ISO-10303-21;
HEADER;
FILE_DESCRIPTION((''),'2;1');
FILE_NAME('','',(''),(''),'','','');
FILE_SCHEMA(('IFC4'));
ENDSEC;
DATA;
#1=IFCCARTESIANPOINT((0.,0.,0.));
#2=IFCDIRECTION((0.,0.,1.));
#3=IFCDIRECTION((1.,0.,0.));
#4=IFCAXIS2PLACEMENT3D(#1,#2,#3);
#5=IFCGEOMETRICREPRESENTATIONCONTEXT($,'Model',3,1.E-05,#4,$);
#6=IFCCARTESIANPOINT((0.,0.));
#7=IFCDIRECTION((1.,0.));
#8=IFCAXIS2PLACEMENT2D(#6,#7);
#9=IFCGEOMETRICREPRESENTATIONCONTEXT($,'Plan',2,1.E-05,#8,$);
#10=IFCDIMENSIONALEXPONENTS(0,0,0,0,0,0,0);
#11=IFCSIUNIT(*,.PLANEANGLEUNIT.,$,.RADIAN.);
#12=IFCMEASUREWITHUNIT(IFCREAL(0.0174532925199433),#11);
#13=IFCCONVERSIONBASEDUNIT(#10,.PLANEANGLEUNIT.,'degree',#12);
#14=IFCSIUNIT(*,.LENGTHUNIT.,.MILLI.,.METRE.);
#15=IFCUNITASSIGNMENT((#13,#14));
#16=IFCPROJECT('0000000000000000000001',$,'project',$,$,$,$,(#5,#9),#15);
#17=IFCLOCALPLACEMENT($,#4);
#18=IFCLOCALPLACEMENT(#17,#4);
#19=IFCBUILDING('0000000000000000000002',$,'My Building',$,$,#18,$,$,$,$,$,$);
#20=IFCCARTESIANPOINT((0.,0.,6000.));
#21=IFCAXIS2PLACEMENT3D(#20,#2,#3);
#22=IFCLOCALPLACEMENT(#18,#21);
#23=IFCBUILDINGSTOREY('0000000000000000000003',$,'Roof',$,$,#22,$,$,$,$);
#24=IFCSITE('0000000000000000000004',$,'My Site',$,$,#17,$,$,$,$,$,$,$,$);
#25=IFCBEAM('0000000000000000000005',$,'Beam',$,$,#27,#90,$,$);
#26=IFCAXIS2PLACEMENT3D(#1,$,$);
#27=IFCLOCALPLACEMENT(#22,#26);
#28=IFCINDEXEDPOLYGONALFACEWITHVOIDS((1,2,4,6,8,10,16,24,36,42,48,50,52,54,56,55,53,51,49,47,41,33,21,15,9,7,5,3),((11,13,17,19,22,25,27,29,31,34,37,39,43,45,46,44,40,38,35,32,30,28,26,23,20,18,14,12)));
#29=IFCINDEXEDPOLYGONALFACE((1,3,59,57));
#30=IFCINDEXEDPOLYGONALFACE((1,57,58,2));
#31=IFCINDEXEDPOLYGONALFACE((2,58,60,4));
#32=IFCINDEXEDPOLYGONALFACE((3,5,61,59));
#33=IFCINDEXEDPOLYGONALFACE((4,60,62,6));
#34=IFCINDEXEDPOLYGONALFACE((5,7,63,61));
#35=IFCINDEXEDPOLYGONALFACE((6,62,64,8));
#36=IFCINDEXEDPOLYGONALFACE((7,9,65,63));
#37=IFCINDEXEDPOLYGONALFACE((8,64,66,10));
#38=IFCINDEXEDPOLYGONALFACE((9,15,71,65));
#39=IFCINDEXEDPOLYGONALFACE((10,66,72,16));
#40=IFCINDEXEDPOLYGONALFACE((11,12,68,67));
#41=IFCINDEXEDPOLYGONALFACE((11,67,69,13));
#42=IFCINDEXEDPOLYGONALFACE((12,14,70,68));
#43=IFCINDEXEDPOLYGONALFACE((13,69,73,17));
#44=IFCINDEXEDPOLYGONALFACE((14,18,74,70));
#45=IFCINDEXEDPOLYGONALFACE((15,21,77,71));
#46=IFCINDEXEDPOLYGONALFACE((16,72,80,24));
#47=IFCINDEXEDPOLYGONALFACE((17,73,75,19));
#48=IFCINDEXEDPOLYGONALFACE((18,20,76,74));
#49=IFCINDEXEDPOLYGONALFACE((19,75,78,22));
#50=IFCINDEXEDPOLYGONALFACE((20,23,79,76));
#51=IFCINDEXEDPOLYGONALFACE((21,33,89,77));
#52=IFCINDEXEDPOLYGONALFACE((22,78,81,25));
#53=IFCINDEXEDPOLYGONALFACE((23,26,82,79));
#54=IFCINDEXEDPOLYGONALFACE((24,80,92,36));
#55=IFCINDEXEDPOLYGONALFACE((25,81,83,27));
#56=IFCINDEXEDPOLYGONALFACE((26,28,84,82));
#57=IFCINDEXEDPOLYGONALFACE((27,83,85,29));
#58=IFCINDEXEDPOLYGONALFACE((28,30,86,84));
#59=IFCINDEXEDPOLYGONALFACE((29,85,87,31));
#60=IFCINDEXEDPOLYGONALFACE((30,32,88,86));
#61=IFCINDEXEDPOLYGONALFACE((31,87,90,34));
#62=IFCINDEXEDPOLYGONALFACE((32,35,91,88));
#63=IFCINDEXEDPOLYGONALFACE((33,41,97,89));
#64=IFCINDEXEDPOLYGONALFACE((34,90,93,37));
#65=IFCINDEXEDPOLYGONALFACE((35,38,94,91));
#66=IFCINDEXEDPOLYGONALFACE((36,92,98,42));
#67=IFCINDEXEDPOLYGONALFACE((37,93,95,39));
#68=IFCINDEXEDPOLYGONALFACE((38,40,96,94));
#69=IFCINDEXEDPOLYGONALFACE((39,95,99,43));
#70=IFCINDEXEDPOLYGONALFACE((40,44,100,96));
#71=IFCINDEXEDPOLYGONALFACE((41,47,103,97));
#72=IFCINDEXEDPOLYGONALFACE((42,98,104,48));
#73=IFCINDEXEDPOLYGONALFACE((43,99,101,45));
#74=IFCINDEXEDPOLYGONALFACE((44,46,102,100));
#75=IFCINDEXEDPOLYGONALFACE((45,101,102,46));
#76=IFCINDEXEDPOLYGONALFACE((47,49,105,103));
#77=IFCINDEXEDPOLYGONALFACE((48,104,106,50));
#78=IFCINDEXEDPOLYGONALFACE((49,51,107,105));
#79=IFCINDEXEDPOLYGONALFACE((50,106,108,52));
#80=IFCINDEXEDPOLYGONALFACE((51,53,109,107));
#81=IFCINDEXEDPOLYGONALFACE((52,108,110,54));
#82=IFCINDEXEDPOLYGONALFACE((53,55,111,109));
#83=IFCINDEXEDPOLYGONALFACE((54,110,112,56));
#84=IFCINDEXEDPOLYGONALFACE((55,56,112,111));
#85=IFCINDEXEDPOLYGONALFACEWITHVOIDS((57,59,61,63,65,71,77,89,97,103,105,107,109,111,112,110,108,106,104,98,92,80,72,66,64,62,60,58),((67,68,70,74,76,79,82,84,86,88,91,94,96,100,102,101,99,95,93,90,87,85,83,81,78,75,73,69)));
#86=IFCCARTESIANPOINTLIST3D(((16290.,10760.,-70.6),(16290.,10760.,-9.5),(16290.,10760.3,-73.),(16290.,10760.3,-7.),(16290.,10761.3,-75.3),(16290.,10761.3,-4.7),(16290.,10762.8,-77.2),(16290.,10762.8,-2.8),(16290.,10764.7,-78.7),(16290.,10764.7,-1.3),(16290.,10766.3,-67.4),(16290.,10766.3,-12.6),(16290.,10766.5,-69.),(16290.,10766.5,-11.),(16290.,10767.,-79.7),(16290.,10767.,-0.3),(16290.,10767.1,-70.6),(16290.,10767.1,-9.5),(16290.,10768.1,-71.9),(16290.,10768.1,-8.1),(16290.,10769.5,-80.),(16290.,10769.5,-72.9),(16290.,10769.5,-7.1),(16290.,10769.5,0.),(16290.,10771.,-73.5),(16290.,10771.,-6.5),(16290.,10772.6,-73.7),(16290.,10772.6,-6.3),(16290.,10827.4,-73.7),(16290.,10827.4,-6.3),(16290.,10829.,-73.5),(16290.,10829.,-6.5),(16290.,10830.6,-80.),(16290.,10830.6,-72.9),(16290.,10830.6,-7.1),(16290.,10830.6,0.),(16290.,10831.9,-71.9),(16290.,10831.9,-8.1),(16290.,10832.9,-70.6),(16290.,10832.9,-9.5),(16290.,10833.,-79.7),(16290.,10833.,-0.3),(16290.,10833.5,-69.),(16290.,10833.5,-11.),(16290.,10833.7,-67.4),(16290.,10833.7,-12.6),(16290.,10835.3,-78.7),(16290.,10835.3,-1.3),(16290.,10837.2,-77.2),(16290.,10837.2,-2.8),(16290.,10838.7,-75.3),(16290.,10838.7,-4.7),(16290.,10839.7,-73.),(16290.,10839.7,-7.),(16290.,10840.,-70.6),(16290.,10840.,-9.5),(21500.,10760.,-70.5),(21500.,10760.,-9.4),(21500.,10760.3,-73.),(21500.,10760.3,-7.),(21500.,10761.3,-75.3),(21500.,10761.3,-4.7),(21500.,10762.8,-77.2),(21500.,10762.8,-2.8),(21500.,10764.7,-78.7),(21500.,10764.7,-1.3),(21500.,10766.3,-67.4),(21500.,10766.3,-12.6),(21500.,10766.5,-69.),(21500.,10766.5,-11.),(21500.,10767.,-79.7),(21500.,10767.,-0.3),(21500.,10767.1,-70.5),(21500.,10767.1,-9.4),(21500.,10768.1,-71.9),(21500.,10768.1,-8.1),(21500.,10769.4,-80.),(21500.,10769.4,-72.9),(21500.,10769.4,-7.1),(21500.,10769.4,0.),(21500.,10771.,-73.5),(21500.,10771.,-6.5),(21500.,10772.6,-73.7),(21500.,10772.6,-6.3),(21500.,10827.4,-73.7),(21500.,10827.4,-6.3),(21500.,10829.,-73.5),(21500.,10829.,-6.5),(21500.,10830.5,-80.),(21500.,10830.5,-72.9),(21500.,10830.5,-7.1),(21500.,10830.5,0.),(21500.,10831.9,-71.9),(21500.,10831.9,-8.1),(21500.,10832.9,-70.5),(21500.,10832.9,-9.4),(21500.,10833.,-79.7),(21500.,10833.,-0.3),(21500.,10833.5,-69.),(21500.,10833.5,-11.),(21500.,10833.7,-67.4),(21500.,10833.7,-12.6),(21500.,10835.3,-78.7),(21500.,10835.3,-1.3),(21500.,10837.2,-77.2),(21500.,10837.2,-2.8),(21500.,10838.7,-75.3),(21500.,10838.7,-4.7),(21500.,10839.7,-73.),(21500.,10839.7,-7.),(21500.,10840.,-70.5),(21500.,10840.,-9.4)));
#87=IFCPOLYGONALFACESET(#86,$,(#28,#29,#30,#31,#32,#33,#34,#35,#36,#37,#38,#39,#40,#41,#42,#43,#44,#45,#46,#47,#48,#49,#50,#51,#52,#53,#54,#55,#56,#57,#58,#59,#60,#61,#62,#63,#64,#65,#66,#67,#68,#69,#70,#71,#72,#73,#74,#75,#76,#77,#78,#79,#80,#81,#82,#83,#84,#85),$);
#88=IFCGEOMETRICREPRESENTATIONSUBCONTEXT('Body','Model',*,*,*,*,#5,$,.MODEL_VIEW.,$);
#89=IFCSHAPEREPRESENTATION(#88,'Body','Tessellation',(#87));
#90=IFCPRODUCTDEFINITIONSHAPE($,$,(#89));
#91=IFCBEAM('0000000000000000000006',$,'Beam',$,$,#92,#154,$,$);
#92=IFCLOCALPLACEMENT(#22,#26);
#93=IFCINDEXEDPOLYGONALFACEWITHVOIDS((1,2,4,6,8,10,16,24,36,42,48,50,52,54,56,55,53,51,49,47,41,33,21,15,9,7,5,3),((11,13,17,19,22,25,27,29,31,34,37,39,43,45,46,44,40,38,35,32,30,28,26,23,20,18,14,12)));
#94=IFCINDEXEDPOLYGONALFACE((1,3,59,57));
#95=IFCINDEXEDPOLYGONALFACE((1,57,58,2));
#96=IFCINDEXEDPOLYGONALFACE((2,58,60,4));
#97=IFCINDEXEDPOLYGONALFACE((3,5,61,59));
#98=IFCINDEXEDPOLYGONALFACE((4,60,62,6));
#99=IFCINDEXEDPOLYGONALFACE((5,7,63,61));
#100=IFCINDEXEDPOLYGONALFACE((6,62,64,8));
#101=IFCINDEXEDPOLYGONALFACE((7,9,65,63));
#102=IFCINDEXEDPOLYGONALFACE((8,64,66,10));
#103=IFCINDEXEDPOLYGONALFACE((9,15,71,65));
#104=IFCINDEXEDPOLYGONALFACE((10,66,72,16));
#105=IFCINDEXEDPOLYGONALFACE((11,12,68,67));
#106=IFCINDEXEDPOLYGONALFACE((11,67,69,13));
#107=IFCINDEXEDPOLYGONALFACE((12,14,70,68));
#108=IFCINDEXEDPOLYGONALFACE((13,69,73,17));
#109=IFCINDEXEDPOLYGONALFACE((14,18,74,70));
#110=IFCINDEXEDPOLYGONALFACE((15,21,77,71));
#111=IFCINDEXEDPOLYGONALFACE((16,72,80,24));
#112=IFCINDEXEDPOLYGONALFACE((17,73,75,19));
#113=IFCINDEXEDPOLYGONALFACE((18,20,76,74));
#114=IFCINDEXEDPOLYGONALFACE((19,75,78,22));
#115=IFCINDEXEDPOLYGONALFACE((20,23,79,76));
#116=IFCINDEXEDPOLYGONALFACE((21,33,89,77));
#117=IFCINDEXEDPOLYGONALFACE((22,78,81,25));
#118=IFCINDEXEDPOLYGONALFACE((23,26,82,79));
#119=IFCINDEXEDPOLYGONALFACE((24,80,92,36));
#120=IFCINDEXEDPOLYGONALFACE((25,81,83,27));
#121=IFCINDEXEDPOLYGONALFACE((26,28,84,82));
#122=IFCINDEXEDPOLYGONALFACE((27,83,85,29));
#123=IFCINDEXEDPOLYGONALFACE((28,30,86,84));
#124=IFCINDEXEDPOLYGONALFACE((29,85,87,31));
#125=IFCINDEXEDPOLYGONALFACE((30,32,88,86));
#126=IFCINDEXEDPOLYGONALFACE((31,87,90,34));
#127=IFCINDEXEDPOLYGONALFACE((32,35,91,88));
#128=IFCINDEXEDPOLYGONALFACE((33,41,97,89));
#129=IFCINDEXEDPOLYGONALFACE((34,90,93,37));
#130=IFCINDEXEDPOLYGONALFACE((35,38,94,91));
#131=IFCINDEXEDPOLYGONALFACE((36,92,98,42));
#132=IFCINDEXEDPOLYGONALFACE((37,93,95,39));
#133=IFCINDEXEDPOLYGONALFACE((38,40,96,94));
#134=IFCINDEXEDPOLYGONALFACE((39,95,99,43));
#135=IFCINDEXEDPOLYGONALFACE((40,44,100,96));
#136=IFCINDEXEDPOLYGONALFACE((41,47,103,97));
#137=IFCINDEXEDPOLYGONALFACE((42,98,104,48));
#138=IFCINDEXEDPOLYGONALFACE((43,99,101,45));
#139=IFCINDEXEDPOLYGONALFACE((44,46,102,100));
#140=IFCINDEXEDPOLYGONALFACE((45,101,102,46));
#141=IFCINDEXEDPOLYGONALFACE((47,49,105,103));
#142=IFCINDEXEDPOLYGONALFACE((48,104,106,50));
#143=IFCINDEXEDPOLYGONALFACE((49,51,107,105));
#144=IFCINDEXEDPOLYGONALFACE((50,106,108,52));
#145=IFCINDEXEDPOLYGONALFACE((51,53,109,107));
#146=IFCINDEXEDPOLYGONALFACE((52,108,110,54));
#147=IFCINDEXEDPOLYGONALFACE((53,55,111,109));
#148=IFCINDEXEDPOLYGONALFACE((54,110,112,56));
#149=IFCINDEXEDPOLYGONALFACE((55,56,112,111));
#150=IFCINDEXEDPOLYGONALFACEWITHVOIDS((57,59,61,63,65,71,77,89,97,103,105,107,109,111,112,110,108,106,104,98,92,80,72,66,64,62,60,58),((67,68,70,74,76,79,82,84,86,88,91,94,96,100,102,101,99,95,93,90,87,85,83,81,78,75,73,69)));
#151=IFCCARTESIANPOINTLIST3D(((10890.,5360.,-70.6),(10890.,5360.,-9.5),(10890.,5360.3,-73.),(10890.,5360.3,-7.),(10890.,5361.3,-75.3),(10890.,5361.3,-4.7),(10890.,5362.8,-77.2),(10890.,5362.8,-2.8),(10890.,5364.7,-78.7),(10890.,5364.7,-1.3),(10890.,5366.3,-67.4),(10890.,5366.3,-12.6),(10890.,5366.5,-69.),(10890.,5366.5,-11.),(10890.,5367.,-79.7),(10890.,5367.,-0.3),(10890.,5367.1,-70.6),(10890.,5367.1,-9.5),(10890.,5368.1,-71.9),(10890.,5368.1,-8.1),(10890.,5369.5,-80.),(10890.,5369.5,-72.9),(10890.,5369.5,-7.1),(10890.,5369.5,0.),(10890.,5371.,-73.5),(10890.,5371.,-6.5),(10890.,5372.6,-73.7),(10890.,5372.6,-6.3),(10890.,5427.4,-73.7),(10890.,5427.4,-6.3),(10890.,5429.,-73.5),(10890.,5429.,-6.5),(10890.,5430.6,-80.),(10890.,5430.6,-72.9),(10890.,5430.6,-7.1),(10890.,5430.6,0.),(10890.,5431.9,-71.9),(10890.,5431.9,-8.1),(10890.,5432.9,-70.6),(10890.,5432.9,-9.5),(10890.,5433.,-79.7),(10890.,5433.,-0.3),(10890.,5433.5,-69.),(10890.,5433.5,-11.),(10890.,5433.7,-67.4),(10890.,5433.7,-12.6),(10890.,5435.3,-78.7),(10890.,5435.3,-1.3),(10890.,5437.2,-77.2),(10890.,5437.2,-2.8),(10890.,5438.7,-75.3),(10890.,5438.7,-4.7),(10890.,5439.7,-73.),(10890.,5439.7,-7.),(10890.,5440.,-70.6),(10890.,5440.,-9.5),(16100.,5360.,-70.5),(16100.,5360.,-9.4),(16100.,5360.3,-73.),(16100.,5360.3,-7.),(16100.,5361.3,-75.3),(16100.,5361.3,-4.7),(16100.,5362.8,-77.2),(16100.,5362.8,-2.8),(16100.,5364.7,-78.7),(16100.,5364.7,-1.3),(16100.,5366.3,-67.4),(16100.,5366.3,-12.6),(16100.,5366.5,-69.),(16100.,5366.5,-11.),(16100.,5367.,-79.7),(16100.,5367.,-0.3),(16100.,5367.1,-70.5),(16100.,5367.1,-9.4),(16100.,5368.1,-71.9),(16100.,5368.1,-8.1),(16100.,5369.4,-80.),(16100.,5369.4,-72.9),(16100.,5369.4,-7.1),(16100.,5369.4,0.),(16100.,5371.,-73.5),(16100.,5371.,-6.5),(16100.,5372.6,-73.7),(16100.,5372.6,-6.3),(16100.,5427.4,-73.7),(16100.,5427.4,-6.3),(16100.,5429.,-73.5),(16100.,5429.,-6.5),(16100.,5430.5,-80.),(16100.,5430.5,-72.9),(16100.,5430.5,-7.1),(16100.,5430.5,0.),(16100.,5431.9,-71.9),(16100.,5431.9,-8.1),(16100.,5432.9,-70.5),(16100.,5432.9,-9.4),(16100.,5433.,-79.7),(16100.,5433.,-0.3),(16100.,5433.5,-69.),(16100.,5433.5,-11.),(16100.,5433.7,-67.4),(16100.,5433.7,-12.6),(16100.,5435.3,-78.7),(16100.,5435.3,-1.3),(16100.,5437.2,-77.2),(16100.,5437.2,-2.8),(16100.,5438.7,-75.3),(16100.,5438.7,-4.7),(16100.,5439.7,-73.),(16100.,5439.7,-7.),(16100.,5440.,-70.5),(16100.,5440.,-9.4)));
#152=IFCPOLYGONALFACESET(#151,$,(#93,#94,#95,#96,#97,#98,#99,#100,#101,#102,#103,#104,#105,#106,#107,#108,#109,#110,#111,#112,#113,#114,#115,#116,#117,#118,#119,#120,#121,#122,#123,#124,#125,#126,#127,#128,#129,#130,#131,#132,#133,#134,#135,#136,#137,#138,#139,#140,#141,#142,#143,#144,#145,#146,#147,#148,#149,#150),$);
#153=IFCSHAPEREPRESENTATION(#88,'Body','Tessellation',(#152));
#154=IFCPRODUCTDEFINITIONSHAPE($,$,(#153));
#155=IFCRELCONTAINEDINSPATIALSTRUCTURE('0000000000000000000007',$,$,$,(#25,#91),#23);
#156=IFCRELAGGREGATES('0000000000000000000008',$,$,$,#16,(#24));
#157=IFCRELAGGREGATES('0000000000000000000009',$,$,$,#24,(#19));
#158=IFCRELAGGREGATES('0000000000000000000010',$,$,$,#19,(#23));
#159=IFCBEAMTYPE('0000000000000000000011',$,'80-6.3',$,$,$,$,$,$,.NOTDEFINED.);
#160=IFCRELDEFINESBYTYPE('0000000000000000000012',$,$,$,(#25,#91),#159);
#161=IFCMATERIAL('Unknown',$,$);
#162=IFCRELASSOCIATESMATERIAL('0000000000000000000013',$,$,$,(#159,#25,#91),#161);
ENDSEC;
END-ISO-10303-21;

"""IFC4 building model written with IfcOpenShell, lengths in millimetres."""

from ifc_helpers import new_model, entity, si_unit, converted_unit, frame, origin_with_axes, origin_2d_with_axis, place, context, subcontext, project, spatial, hollow_rectangle, extrude, material, material_profile, profile_set, profile_usage, type_object, element, save


model = new_model("IFC4")

# Units and contexts
model_context = context("Model", 3, precision=1e-05, world=origin_with_axes())
plan_context = context("Plan", 2, precision=1e-05, world=origin_2d_with_axis())
body_context = subcontext(model_context, "Body", "Model", "MODEL_VIEW")
ifc_project = project(units=[converted_unit("PLANEANGLEUNIT", "degree", entity("IfcReal", 0.0174532925199433), si_unit("PLANEANGLEUNIT", "RADIAN"), dimensions=[0, 0, 0, 0, 0, 0, 0]), si_unit("LENGTHUNIT", "METRE", prefix="MILLI")], contexts=[model_context, plan_context])

# Site, building, storey
site_placement = place(None, origin_with_axes())
site = spatial("IfcSite", under=ifc_project, at=site_placement, Name="My Site")
building_placement = place(site_placement, origin_with_axes())
building = spatial("IfcBuilding", under=site, at=building_placement, Name="My Building")
storey_placement = place(building_placement, frame((0.0, 0.0, 6000.0), z_axis=(0.0, 0.0, 1.0), x_axis=(1.0, 0.0, 0.0)))
storey = spatial("IfcBuildingStorey", under=building, at=storey_placement, Name="Roof")

# Beams
ifc_material = material(Name="Unknown")
ifc_material_profile_1 = material_profile(ifc_material, hollow_rectangle(XDim=80.0, YDim=80.0, WallThickness=6.3, InnerFilletRadius=6.3, OuterFilletRadius=9.4))
ifc_profile_set_1 = profile_set([ifc_material_profile_1])
ifc_profile_usage_1 = profile_usage(ifc_profile_set_1, cardinal=8)
beam_type_1 = type_object("IfcBeamType", Name="80-6.3", PredefinedType="NOTDEFINED", material=ifc_profile_set_1)
beam_1_placement = place(storey_placement, frame((16290.0, 10800.0, 0.0), z_axis=(1.0, 0.0, 0.0), x_axis=(0.0, 1.0, 0.0)))
element("IfcBeam", 1, at=beam_1_placement, inside=storey, type_object=beam_type_1, material=ifc_profile_usage_1, Name="Beam", context=body_context, shape_type="SweptSolid", body=[
    extrude(hollow_rectangle(XDim=80.0, YDim=80.0, WallThickness=6.3, InnerFilletRadius=6.3, OuterFilletRadius=9.4), frame((0.0, -40.0, 0.0), z_axis=(0.0, 0.0, 1.0), x_axis=(1.0, 0.0, 0.0)), (0.0, 0.0, 1.0), 5210.0),
])
ifc_profile_usage_2 = profile_usage(ifc_profile_set_1, cardinal=8)
beam_2_placement = place(storey_placement, frame((10890.0, 5400.0, 0.0), z_axis=(1.0, 0.0, 0.0), x_axis=(0.0, 1.0, 0.0)))
element("IfcBeam", 2, at=beam_2_placement, inside=storey, type_object=beam_type_1, material=ifc_profile_usage_2, Name="Beam", context=body_context, shape_type="SweptSolid", body=[
    extrude(hollow_rectangle(XDim=80.0, YDim=80.0, WallThickness=6.3, InnerFilletRadius=6.3, OuterFilletRadius=9.4), frame((0.0, -40.0, 0.0), z_axis=(0.0, 0.0, 1.0), x_axis=(1.0, 0.0, 0.0)), (0.0, 0.0, 1.0), 5210.0),
])

save(model, "model.ifc")
